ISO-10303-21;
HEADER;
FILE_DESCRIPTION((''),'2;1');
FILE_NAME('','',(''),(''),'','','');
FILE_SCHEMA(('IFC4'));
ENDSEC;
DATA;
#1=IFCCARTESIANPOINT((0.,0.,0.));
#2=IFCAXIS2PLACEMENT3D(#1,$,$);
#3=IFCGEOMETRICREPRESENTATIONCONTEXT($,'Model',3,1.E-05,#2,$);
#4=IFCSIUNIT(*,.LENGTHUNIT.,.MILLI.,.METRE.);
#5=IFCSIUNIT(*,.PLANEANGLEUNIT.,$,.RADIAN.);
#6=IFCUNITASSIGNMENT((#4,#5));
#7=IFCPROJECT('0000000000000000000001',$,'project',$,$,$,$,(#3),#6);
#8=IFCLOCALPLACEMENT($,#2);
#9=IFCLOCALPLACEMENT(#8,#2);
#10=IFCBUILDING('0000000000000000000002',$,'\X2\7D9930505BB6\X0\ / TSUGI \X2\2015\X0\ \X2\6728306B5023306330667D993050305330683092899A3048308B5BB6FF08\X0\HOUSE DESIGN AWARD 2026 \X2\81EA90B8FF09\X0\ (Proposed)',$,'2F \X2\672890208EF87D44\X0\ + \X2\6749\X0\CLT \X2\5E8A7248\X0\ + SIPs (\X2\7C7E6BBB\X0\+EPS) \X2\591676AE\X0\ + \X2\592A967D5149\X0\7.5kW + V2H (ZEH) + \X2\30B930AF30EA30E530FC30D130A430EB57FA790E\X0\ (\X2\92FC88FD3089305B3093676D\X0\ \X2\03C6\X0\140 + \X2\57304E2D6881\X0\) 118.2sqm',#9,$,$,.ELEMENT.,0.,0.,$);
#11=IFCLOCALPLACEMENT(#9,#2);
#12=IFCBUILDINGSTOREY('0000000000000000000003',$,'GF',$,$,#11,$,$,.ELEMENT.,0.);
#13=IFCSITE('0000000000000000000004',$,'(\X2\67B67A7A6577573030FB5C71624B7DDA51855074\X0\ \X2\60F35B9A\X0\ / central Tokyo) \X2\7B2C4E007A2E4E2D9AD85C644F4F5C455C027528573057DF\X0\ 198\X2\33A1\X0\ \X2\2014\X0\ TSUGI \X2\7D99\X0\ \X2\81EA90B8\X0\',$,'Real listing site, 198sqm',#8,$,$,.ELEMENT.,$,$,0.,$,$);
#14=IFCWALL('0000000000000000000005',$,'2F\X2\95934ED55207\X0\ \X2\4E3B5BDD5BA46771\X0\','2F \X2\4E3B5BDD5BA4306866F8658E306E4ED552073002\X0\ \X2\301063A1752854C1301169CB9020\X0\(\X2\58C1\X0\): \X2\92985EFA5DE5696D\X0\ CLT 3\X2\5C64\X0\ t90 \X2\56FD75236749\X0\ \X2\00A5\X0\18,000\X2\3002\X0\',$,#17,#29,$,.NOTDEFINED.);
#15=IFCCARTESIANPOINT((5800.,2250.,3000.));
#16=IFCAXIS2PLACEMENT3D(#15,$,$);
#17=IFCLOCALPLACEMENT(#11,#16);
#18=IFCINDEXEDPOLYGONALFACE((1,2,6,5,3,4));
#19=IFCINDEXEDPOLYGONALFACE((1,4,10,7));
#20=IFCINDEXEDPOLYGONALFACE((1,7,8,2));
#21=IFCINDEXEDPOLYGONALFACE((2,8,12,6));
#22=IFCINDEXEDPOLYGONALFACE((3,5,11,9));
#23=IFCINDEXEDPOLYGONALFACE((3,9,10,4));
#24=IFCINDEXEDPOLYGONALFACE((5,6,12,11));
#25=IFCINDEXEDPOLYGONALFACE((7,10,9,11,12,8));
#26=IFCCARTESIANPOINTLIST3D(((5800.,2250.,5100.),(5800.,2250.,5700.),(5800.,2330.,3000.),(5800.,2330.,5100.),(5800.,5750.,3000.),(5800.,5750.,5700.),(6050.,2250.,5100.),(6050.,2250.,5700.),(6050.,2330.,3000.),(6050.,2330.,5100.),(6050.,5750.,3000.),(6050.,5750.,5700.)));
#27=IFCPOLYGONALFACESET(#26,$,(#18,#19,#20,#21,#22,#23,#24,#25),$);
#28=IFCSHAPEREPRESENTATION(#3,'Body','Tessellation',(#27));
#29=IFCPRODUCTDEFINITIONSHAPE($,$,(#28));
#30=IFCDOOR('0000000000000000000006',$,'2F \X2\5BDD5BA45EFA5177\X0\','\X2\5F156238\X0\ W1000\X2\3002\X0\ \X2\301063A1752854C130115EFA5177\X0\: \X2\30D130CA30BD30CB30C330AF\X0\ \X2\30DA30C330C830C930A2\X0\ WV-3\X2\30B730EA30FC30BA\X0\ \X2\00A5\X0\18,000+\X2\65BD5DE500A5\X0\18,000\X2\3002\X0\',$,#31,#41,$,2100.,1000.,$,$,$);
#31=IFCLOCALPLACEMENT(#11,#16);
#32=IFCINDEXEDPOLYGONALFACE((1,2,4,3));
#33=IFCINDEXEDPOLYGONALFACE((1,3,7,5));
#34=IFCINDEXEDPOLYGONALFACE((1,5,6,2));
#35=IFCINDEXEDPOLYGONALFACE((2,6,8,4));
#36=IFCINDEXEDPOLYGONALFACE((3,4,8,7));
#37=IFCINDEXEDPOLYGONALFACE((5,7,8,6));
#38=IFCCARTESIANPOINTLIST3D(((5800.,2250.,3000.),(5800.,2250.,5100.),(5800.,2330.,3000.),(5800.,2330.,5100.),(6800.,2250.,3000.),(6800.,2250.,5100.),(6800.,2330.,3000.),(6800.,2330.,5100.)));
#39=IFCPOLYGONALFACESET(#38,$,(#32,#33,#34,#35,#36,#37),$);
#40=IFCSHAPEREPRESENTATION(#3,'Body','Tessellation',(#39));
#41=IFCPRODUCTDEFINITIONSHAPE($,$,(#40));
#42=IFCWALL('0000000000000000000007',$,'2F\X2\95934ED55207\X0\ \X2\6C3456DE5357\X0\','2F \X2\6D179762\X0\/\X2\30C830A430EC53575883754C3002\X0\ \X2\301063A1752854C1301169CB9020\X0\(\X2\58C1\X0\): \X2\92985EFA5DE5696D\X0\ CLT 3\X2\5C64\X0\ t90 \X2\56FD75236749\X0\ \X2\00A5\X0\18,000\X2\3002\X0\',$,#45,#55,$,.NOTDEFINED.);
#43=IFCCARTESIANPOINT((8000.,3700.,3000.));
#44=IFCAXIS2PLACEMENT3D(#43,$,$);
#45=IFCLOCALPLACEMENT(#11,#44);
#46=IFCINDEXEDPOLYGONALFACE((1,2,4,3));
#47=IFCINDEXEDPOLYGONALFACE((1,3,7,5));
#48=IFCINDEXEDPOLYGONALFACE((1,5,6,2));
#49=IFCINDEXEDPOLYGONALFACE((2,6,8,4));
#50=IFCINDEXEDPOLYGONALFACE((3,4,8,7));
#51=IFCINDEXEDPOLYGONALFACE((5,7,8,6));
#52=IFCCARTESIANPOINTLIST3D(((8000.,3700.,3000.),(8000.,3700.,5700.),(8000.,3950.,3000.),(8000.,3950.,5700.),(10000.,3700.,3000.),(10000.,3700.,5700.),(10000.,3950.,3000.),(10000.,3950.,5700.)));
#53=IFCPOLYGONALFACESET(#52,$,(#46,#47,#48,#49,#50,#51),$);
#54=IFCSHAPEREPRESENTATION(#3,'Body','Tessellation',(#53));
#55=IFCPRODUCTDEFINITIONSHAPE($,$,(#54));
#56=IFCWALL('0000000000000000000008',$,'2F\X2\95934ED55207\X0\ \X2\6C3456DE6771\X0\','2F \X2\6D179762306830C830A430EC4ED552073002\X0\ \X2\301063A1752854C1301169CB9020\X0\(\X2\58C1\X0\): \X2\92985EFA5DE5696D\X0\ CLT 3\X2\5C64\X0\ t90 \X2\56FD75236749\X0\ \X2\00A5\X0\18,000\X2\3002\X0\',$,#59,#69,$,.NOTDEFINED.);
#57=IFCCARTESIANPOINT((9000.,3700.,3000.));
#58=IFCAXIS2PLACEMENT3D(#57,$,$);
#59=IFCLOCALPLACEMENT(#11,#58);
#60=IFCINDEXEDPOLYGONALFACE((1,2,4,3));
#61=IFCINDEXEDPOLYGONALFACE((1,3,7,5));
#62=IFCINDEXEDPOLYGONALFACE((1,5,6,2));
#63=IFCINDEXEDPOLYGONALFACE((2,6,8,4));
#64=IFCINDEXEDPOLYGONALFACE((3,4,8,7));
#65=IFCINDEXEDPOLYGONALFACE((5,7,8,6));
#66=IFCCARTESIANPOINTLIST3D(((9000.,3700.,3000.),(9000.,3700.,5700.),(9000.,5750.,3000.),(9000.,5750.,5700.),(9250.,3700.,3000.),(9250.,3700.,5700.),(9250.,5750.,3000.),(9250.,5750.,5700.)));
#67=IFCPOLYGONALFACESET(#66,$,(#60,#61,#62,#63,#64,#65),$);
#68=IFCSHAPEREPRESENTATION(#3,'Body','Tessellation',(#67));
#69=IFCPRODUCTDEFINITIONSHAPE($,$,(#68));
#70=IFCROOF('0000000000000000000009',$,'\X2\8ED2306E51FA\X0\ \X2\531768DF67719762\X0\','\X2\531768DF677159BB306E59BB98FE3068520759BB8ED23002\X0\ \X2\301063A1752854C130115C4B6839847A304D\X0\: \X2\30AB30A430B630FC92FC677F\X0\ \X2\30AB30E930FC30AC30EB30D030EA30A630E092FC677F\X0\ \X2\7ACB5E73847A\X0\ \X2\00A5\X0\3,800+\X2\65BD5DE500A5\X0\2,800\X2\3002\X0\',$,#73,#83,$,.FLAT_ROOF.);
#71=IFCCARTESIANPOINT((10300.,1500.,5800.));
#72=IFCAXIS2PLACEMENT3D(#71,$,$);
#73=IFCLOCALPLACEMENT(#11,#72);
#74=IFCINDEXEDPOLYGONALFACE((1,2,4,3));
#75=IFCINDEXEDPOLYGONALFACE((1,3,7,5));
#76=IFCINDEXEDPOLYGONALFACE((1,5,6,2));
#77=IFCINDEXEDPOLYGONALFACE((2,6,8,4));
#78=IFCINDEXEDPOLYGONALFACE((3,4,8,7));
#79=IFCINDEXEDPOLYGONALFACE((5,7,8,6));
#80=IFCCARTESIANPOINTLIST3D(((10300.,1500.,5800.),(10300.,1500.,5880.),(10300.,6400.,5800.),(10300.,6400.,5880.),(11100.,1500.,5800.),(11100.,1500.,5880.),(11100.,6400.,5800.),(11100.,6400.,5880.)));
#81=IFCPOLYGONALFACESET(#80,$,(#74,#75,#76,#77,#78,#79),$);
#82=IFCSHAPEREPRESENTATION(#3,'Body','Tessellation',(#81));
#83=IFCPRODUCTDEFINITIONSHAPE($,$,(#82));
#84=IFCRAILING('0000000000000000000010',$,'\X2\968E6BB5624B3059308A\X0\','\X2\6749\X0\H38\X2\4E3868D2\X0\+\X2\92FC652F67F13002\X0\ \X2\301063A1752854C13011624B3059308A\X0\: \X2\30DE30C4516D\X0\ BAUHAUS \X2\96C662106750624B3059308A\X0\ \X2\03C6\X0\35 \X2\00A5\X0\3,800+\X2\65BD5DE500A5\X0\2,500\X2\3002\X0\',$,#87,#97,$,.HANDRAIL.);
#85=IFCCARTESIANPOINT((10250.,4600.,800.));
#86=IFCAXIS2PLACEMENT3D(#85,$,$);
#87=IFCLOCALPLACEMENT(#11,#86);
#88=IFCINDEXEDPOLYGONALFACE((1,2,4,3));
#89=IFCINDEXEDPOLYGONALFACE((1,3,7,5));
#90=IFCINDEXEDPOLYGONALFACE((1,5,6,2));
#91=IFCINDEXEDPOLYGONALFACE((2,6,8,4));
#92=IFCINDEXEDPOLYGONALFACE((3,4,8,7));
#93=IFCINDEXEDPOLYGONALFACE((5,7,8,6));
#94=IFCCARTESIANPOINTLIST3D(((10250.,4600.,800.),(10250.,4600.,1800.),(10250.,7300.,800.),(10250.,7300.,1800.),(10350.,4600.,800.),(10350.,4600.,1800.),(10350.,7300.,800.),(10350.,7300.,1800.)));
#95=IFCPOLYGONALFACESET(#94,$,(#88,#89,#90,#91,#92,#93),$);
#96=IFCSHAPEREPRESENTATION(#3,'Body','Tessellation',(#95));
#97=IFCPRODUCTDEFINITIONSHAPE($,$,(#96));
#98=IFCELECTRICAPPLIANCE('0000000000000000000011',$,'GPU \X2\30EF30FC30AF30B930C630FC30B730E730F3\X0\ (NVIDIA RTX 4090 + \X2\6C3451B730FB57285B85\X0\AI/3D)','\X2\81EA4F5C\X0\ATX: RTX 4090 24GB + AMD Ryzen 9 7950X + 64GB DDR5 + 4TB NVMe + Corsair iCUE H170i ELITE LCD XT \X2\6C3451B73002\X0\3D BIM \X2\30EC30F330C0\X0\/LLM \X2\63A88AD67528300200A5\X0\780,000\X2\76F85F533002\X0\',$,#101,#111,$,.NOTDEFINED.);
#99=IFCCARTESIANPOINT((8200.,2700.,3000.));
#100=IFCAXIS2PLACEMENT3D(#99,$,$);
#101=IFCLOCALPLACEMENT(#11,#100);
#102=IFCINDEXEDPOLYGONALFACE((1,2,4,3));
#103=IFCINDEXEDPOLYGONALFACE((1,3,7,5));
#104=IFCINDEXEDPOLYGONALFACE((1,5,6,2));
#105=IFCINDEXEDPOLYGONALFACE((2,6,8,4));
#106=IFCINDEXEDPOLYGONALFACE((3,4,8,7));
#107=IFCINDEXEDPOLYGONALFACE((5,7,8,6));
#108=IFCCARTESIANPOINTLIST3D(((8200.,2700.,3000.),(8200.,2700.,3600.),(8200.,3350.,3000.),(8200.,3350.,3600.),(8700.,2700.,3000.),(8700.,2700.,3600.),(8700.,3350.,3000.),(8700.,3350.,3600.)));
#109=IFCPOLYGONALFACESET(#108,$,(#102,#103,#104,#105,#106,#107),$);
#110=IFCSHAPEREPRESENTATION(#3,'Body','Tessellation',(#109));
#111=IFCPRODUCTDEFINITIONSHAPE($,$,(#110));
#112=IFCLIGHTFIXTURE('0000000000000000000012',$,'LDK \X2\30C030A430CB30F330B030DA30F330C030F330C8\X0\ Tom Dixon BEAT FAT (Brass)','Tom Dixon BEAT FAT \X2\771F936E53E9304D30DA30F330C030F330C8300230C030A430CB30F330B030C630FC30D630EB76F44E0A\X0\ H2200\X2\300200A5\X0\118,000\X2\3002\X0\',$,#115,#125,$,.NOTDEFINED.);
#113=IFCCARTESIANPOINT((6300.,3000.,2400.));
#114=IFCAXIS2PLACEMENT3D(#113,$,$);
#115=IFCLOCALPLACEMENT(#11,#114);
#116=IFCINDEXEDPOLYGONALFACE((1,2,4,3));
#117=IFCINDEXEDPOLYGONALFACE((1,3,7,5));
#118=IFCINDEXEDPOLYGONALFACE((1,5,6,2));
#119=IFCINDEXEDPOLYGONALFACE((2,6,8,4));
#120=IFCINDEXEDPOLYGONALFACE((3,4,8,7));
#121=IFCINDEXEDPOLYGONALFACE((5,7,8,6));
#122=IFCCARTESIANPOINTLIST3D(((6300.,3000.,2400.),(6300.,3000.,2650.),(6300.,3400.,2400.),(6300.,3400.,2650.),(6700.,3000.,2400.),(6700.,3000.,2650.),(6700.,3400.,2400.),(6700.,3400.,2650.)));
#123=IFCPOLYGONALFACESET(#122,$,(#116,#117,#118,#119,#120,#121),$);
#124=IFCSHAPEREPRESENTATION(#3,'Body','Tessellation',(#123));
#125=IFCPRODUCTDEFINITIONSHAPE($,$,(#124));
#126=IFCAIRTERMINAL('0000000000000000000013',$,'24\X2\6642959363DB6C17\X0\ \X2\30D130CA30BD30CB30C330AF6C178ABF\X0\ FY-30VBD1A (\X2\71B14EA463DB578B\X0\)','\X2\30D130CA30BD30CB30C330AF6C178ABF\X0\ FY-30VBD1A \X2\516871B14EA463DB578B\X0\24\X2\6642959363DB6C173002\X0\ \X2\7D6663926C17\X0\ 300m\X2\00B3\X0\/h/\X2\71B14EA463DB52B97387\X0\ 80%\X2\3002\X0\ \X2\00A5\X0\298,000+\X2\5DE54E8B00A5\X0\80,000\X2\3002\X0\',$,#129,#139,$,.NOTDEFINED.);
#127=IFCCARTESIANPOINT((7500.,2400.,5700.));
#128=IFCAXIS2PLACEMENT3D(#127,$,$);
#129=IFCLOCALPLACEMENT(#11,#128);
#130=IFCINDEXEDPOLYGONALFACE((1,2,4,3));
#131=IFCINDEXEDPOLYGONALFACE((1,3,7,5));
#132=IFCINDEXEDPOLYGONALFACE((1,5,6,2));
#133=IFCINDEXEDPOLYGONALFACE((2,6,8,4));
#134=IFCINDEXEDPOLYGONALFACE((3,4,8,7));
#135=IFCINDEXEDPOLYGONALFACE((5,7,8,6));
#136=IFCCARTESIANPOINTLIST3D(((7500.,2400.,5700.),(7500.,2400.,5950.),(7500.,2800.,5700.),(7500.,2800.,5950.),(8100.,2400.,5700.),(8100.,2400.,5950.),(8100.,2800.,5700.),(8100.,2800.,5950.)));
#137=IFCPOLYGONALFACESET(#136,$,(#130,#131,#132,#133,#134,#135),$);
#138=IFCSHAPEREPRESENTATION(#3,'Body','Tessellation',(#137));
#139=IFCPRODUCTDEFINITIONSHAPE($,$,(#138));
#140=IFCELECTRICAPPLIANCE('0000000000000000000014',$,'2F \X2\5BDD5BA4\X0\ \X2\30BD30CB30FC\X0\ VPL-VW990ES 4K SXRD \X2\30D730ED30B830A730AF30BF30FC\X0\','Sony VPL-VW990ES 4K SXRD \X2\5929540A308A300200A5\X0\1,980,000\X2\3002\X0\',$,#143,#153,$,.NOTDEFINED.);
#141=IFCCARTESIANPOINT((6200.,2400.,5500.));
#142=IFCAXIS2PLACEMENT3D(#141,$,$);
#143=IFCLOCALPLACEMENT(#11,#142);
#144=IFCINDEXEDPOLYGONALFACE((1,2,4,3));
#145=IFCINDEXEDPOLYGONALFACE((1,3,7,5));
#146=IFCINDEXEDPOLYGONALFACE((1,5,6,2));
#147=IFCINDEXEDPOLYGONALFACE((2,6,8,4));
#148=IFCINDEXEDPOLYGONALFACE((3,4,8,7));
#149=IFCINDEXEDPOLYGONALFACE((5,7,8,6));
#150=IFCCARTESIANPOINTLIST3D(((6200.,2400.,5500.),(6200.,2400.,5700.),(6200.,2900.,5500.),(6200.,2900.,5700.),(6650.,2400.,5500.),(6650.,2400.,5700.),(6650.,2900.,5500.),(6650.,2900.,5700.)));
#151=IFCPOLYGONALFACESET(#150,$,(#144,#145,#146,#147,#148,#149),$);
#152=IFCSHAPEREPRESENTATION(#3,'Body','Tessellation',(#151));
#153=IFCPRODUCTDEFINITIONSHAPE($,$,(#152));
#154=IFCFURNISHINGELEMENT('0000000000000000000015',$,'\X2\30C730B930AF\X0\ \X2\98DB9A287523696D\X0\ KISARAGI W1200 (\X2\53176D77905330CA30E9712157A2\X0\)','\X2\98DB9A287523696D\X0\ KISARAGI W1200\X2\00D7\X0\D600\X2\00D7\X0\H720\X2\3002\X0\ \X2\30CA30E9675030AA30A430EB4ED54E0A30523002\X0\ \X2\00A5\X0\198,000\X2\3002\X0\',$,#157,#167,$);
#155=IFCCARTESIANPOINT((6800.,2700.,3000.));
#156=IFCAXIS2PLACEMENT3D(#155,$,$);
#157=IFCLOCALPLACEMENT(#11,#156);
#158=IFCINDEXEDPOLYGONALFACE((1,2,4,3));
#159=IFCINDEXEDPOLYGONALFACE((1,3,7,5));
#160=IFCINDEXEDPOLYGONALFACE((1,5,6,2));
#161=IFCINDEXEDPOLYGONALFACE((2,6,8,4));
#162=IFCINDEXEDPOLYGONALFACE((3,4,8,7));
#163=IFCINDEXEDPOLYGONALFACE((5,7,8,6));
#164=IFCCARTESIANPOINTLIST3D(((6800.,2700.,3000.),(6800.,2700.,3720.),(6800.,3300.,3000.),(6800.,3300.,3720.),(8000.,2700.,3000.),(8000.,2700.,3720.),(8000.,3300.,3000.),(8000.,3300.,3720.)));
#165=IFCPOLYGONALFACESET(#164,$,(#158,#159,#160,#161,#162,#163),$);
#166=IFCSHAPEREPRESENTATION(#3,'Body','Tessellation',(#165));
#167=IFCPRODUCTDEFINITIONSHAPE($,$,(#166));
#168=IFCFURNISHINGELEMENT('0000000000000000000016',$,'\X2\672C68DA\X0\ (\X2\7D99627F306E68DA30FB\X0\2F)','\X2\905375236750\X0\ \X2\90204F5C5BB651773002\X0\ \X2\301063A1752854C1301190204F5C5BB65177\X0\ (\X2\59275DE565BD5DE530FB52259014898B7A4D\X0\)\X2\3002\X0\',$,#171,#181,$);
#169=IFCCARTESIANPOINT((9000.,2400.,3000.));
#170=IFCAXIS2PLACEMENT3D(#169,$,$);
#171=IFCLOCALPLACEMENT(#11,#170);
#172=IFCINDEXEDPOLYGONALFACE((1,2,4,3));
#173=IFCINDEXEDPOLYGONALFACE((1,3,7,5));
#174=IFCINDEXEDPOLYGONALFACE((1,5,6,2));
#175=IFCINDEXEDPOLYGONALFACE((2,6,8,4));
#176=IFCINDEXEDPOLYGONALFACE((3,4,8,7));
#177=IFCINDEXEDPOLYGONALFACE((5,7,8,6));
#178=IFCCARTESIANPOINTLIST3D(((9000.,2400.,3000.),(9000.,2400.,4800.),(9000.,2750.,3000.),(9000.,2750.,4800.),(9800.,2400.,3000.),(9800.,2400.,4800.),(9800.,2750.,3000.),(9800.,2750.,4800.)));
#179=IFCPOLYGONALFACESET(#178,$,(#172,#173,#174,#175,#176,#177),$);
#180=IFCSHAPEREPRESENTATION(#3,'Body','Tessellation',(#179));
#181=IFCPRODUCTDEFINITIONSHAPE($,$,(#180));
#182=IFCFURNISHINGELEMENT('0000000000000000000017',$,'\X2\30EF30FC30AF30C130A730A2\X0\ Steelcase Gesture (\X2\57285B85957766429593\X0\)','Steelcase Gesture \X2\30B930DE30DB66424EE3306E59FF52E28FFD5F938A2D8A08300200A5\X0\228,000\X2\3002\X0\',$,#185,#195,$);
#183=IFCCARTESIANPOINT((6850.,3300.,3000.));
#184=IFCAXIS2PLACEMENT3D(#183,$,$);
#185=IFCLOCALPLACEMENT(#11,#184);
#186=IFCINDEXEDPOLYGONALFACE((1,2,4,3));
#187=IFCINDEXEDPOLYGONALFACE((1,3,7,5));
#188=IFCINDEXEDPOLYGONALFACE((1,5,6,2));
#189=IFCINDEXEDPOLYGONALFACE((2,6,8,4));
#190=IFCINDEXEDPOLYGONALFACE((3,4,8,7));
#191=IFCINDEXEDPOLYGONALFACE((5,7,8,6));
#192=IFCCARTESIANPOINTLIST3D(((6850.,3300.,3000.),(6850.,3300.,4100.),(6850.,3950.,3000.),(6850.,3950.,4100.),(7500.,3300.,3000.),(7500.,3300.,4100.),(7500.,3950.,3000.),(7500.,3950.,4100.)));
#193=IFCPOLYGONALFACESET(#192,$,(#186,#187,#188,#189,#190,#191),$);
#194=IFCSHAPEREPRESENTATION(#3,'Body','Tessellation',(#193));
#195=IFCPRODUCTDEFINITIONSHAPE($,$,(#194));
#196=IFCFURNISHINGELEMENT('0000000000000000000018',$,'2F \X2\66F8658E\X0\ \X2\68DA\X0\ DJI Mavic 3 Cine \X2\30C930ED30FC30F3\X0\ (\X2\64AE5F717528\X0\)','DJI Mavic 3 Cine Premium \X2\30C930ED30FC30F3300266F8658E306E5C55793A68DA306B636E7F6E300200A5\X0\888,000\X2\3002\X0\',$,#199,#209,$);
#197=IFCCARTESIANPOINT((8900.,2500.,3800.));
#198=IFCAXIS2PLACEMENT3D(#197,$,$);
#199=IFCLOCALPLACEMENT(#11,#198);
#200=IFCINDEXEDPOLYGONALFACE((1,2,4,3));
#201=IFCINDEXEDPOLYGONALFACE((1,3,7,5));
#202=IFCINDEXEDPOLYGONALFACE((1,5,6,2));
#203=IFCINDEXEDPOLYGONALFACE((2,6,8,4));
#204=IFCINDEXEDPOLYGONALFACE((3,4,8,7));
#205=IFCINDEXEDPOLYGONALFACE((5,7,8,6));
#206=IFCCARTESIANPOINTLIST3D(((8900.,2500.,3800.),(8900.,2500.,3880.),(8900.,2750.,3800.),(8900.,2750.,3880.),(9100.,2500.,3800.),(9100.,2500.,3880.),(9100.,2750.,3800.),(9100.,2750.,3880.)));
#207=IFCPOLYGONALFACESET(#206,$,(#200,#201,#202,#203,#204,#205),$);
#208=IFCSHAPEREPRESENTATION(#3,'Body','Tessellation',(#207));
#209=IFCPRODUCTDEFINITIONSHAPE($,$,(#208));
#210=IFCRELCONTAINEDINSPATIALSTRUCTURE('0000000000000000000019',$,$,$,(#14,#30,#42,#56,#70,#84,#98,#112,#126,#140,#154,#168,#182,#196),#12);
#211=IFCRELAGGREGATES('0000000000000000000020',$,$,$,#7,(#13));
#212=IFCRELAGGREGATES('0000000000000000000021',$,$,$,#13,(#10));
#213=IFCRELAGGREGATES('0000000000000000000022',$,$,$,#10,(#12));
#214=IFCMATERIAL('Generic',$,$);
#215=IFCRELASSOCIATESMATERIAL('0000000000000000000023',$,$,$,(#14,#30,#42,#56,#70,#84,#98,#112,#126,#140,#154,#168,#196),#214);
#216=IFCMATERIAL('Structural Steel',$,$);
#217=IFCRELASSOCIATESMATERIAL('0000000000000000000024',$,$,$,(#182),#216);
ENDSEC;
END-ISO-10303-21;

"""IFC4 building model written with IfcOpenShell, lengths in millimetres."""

from ifc_helpers import new_model, si_unit, frame, frame_2d, origin, place, context, project, spatial, rectangle, extrude, material, element, fill, save


model = new_model("IFC4")

# Units and contexts
model_context = context("Model", 3, precision=1e-05, world=origin())
ifc_project = project(units=[si_unit("LENGTHUNIT", "METRE", prefix="MILLI"), si_unit("PLANEANGLEUNIT", "RADIAN")], contexts=[model_context])

# Site, building, storey
site_placement = place(None, origin())
site = spatial("IfcSite", under=ifc_project, at=site_placement, Name="(架空敷地・山手線内側 想定 / central Tokyo) 第一種中高層住居専用地域 198㎡ — TSUGI 継 自邸", ObjectType="Real listing site, 198sqm", CompositionType="ELEMENT", RefElevation=0.0)
building_placement = place(site_placement, origin())
building = spatial("IfcBuilding", under=site, at=building_placement, Name="継ぐ家 / TSUGI ― 木に倣って継ぐことを覚える家（HOUSE DESIGN AWARD 2026 自邸） (Proposed)", ObjectType="2F 木造軸組 + 杉CLT 床版 + SIPs (籾殻+EPS) 外皮 + 太陽光7.5kW + V2H (ZEH) + スクリューパイル基礎 (鋼製らせん杭 φ140 + 地中梁) 118.2sqm", CompositionType="ELEMENT", ElevationOfRefHeight=0.0, ElevationOfTerrain=0.0)
storey_placement = place(building_placement, origin())
storey = spatial("IfcBuildingStorey", under=building, at=storey_placement, Name="GF", CompositionType="ELEMENT", Elevation=0.0)

# Shared definitions
ifc_material_1 = material(Name="Generic")

# Wall, opening, door
wall_1_placement = place(storey_placement, frame((5800.0, 2250.0, 3000.0)))
wall_1 = element("IfcWall", 1, at=wall_1_placement, inside=storey, material=ifc_material_1, Name="2F間仕切 主寝室東", Description="2F 主寝室と書斎の仕切。 【採用品】構造(壁): 銘建工業 CLT 3層 t90 国産杉 ¥18,000。", PredefinedType="NOTDEFINED", context=model_context, shape_type="SweptSolid", body=[
    extrude(rectangle(XDim=250.0, YDim=3500.0, at=frame_2d((125.0, 1750.0))), frame((5800.0, 2250.0, 3000.0)), (0.0, 0.0, 1.0), 2700.0),
])
opening_placement = place(storey_placement, frame((5800.0, 2250.0, 3000.0)))
opening = element("IfcOpeningElement", 2, at=opening_placement, cuts=wall_1, PredefinedType="NOTDEFINED", context=model_context, shape_type="SweptSolid", body=[
    extrude(rectangle(XDim=1000.0, YDim=80.0, at=frame_2d((500.0, 40.0))), frame((5800.0, 2250.0, 3000.0)), (0.0, 0.0, 1.0), 2100.0),
])
door_placement = place(storey_placement, frame((5800.0, 2250.0, 3000.0)))
door = element("IfcDoor", 3, at=door_placement, inside=storey, material=ifc_material_1, Name="2F 寝室建具", Description="引戸 W1000。 【採用品】建具: パナソニック ペットドア WV-3シリーズ ¥18,000+施工¥18,000。", OverallHeight=2100.0, OverallWidth=1000.0, context=model_context, shape_type="SweptSolid", body=[
    extrude(rectangle(XDim=1000.0, YDim=80.0, at=frame_2d((500.0, 40.0))), frame((5800.0, 2250.0, 3000.0)), (0.0, 0.0, 1.0), 2100.0),
])
fill(opening, door)

# Walls
wall_2_placement = place(storey_placement, frame((8000.0, 3700.0, 3000.0)))
element("IfcWall", 4, at=wall_2_placement, inside=storey, material=ifc_material_1, Name="2F間仕切 水回南", Description="2F 洗面/トイレ南境界。 【採用品】構造(壁): 銘建工業 CLT 3層 t90 国産杉 ¥18,000。", PredefinedType="NOTDEFINED", context=model_context, shape_type="SweptSolid", body=[
    extrude(rectangle(XDim=2000.0, YDim=250.0, at=frame_2d((1000.0, 125.0))), frame((8000.0, 3700.0, 3000.0)), (0.0, 0.0, 1.0), 2700.0),
])
wall_3_placement = place(storey_placement, frame((9000.0, 3700.0, 3000.0)))
element("IfcWall", 5, at=wall_3_placement, inside=storey, material=ifc_material_1, Name="2F間仕切 水回東", Description="2F 洗面とトイレ仕切。 【採用品】構造(壁): 銘建工業 CLT 3層 t90 国産杉 ¥18,000。", PredefinedType="NOTDEFINED", context=model_context, shape_type="SweptSolid", body=[
    extrude(rectangle(XDim=250.0, YDim=2050.0, at=frame_2d((125.0, 1025.0))), frame((9000.0, 3700.0, 3000.0)), (0.0, 0.0, 1.0), 2700.0),
])

# Roof
roof_placement = place(storey_placement, frame((10300.0, 1500.0, 5800.0)))
element("IfcRoof", 6, at=roof_placement, inside=storey, material=ifc_material_1, Name="軒の出 北棟東面", Description="北棟東妻の妻飾と切妻軒。 【採用品】屋根葺き: カイザー鋼板 カラーガルバリウム鋼板 立平葺 ¥3,800+施工¥2,800。", PredefinedType="FLAT_ROOF", context=model_context, shape_type="SweptSolid", body=[
    extrude(rectangle(XDim=800.0, YDim=4900.0, at=frame_2d((400.0, 2450.0))), frame((10300.0, 1500.0, 5800.0)), (0.0, 0.0, 1.0), 80.0),
])

# Railing
railing_placement = place(storey_placement, frame((10250.0, 4600.0, 800.0)))
element("IfcRailing", 7, at=railing_placement, inside=storey, material=ifc_material_1, Name="階段手すり", Description="杉H38丸棒+鋼支柱。 【採用品】手すり: マツ六 BAUHAUS 集成材手すり φ35 ¥3,800+施工¥2,500。", PredefinedType="HANDRAIL", context=model_context, shape_type="SweptSolid", body=[
    extrude(rectangle(XDim=100.0, YDim=2700.0, at=frame_2d((50.0, 1350.0))), frame((10250.0, 4600.0, 800.0)), (0.0, 0.0, 1.0), 1000.0),
])

# Electric appliance
electric_appliance_1_placement = place(storey_placement, frame((8200.0, 2700.0, 3000.0)))
element("IfcElectricAppliance", 8, at=electric_appliance_1_placement, inside=storey, material=ifc_material_1, Name="GPU ワークステーション (NVIDIA RTX 4090 + 水冷・在宅AI/3D)", Description="自作ATX: RTX 4090 24GB + AMD Ryzen 9 7950X + 64GB DDR5 + 4TB NVMe + Corsair iCUE H170i ELITE LCD XT 水冷。3D BIM レンダ/LLM 推論用。¥780,000相当。", PredefinedType="NOTDEFINED", context=model_context, shape_type="SweptSolid", body=[
    extrude(rectangle(XDim=500.0, YDim=650.0, at=frame_2d((250.0, 325.0))), frame((8200.0, 2700.0, 3000.0)), (0.0, 0.0, 1.0), 600.0),
])

# Light fixture
light_fixture_placement = place(storey_placement, frame((6300.0, 3000.0, 2400.0)))
element("IfcLightFixture", 9, at=light_fixture_placement, inside=storey, material=ifc_material_1, Name="LDK ダイニングペンダント Tom Dixon BEAT FAT (Brass)", Description="Tom Dixon BEAT FAT 真鍮叩きペンダント。ダイニングテーブル直上 H2200。¥118,000。", PredefinedType="NOTDEFINED", context=model_context, shape_type="SweptSolid", body=[
    extrude(rectangle(XDim=400.0, YDim=400.0, at=frame_2d((200.0, 200.0))), frame((6300.0, 3000.0, 2400.0)), (0.0, 0.0, 1.0), 250.0),
])

# Air terminal
air_terminal_placement = place(storey_placement, frame((7500.0, 2400.0, 5700.0)))
element("IfcAirTerminal", 10, at=air_terminal_placement, inside=storey, material=ifc_material_1, Name="24時間換気 パナソニック気調 FY-30VBD1A (熱交換型)", Description="パナソニック気調 FY-30VBD1A 全熱交換型24時間換気。 給排気 300m³/h/熱交換効率 80%。 ¥298,000+工事¥80,000。", PredefinedType="NOTDEFINED", context=model_context, shape_type="SweptSolid", body=[
    extrude(rectangle(XDim=600.0, YDim=400.0, at=frame_2d((300.0, 200.0))), frame((7500.0, 2400.0, 5700.0)), (0.0, 0.0, 1.0), 250.0),
])

# Electric appliance
electric_appliance_2_placement = place(storey_placement, frame((6200.0, 2400.0, 5500.0)))
element("IfcElectricAppliance", 11, at=electric_appliance_2_placement, inside=storey, material=ifc_material_1, Name="2F 寝室 ソニー VPL-VW990ES 4K SXRD プロジェクター", Description="Sony VPL-VW990ES 4K SXRD 天吊り。¥1,980,000。", PredefinedType="NOTDEFINED", context=model_context, shape_type="SweptSolid", body=[
    extrude(rectangle(XDim=450.0, YDim=500.0, at=frame_2d((225.0, 250.0))), frame((6200.0, 2400.0, 5500.0)), (0.0, 0.0, 1.0), 200.0),
])

# Furnishing elements
furnishing_1_placement = place(storey_placement, frame((6800.0, 2700.0, 3000.0)))
element("IfcFurnishingElement", 12, at=furnishing_1_placement, inside=storey, material=ifc_material_1, Name="デスク 飛騨産業 KISARAGI W1200 (北海道ナラ無垢)", Description="飛騨産業 KISARAGI W1200×D600×H720。 ナラ材オイル仕上げ。 ¥198,000。", context=model_context, shape_type="SweptSolid", body=[
    extrude(rectangle(XDim=1200.0, YDim=600.0, at=frame_2d((600.0, 300.0))), frame((6800.0, 2700.0, 3000.0)), (0.0, 0.0, 1.0), 720.0),
])
furnishing_2_placement = place(storey_placement, frame((9000.0, 2400.0, 3000.0)))
element("IfcFurnishingElement", 13, at=furnishing_2_placement, inside=storey, material=ifc_material_1, Name="本棚 (継承の棚・2F)", Description="道産材 造作家具。 【採用品】造作家具 (大工施工・別途見積)。", context=model_context, shape_type="SweptSolid", body=[
    extrude(rectangle(XDim=800.0, YDim=350.0, at=frame_2d((400.0, 175.0))), frame((9000.0, 2400.0, 3000.0)), (0.0, 0.0, 1.0), 1800.0),
])
ifc_material_2 = material(Name="Structural Steel")
furnishing_3_placement = place(storey_placement, frame((6850.0, 3300.0, 3000.0)))
element("IfcFurnishingElement", 14, at=furnishing_3_placement, inside=storey, material=ifc_material_2, Name="ワークチェア Steelcase Gesture (在宅長時間)", Description="Steelcase Gesture スマホ時代の姿勢追従設計。¥228,000。", context=model_context, shape_type="SweptSolid", body=[
    extrude(rectangle(XDim=650.0, YDim=650.0, at=frame_2d((325.0, 325.0))), frame((6850.0, 3300.0, 3000.0)), (0.0, 0.0, 1.0), 1100.0),
])
furnishing_4_placement = place(storey_placement, frame((8900.0, 2500.0, 3800.0)))
element("IfcFurnishingElement", 15, at=furnishing_4_placement, inside=storey, material=ifc_material_1, Name="2F 書斎 棚 DJI Mavic 3 Cine ドローン (撮影用)", Description="DJI Mavic 3 Cine Premium ドローン。書斎の展示棚に据置。¥888,000。", context=model_context, shape_type="SweptSolid", body=[
    extrude(rectangle(XDim=200.0, YDim=250.0, at=frame_2d((100.0, 125.0))), frame((8900.0, 2500.0, 3800.0)), (0.0, 0.0, 1.0), 80.0),
])

save(model, "model.ifc")
